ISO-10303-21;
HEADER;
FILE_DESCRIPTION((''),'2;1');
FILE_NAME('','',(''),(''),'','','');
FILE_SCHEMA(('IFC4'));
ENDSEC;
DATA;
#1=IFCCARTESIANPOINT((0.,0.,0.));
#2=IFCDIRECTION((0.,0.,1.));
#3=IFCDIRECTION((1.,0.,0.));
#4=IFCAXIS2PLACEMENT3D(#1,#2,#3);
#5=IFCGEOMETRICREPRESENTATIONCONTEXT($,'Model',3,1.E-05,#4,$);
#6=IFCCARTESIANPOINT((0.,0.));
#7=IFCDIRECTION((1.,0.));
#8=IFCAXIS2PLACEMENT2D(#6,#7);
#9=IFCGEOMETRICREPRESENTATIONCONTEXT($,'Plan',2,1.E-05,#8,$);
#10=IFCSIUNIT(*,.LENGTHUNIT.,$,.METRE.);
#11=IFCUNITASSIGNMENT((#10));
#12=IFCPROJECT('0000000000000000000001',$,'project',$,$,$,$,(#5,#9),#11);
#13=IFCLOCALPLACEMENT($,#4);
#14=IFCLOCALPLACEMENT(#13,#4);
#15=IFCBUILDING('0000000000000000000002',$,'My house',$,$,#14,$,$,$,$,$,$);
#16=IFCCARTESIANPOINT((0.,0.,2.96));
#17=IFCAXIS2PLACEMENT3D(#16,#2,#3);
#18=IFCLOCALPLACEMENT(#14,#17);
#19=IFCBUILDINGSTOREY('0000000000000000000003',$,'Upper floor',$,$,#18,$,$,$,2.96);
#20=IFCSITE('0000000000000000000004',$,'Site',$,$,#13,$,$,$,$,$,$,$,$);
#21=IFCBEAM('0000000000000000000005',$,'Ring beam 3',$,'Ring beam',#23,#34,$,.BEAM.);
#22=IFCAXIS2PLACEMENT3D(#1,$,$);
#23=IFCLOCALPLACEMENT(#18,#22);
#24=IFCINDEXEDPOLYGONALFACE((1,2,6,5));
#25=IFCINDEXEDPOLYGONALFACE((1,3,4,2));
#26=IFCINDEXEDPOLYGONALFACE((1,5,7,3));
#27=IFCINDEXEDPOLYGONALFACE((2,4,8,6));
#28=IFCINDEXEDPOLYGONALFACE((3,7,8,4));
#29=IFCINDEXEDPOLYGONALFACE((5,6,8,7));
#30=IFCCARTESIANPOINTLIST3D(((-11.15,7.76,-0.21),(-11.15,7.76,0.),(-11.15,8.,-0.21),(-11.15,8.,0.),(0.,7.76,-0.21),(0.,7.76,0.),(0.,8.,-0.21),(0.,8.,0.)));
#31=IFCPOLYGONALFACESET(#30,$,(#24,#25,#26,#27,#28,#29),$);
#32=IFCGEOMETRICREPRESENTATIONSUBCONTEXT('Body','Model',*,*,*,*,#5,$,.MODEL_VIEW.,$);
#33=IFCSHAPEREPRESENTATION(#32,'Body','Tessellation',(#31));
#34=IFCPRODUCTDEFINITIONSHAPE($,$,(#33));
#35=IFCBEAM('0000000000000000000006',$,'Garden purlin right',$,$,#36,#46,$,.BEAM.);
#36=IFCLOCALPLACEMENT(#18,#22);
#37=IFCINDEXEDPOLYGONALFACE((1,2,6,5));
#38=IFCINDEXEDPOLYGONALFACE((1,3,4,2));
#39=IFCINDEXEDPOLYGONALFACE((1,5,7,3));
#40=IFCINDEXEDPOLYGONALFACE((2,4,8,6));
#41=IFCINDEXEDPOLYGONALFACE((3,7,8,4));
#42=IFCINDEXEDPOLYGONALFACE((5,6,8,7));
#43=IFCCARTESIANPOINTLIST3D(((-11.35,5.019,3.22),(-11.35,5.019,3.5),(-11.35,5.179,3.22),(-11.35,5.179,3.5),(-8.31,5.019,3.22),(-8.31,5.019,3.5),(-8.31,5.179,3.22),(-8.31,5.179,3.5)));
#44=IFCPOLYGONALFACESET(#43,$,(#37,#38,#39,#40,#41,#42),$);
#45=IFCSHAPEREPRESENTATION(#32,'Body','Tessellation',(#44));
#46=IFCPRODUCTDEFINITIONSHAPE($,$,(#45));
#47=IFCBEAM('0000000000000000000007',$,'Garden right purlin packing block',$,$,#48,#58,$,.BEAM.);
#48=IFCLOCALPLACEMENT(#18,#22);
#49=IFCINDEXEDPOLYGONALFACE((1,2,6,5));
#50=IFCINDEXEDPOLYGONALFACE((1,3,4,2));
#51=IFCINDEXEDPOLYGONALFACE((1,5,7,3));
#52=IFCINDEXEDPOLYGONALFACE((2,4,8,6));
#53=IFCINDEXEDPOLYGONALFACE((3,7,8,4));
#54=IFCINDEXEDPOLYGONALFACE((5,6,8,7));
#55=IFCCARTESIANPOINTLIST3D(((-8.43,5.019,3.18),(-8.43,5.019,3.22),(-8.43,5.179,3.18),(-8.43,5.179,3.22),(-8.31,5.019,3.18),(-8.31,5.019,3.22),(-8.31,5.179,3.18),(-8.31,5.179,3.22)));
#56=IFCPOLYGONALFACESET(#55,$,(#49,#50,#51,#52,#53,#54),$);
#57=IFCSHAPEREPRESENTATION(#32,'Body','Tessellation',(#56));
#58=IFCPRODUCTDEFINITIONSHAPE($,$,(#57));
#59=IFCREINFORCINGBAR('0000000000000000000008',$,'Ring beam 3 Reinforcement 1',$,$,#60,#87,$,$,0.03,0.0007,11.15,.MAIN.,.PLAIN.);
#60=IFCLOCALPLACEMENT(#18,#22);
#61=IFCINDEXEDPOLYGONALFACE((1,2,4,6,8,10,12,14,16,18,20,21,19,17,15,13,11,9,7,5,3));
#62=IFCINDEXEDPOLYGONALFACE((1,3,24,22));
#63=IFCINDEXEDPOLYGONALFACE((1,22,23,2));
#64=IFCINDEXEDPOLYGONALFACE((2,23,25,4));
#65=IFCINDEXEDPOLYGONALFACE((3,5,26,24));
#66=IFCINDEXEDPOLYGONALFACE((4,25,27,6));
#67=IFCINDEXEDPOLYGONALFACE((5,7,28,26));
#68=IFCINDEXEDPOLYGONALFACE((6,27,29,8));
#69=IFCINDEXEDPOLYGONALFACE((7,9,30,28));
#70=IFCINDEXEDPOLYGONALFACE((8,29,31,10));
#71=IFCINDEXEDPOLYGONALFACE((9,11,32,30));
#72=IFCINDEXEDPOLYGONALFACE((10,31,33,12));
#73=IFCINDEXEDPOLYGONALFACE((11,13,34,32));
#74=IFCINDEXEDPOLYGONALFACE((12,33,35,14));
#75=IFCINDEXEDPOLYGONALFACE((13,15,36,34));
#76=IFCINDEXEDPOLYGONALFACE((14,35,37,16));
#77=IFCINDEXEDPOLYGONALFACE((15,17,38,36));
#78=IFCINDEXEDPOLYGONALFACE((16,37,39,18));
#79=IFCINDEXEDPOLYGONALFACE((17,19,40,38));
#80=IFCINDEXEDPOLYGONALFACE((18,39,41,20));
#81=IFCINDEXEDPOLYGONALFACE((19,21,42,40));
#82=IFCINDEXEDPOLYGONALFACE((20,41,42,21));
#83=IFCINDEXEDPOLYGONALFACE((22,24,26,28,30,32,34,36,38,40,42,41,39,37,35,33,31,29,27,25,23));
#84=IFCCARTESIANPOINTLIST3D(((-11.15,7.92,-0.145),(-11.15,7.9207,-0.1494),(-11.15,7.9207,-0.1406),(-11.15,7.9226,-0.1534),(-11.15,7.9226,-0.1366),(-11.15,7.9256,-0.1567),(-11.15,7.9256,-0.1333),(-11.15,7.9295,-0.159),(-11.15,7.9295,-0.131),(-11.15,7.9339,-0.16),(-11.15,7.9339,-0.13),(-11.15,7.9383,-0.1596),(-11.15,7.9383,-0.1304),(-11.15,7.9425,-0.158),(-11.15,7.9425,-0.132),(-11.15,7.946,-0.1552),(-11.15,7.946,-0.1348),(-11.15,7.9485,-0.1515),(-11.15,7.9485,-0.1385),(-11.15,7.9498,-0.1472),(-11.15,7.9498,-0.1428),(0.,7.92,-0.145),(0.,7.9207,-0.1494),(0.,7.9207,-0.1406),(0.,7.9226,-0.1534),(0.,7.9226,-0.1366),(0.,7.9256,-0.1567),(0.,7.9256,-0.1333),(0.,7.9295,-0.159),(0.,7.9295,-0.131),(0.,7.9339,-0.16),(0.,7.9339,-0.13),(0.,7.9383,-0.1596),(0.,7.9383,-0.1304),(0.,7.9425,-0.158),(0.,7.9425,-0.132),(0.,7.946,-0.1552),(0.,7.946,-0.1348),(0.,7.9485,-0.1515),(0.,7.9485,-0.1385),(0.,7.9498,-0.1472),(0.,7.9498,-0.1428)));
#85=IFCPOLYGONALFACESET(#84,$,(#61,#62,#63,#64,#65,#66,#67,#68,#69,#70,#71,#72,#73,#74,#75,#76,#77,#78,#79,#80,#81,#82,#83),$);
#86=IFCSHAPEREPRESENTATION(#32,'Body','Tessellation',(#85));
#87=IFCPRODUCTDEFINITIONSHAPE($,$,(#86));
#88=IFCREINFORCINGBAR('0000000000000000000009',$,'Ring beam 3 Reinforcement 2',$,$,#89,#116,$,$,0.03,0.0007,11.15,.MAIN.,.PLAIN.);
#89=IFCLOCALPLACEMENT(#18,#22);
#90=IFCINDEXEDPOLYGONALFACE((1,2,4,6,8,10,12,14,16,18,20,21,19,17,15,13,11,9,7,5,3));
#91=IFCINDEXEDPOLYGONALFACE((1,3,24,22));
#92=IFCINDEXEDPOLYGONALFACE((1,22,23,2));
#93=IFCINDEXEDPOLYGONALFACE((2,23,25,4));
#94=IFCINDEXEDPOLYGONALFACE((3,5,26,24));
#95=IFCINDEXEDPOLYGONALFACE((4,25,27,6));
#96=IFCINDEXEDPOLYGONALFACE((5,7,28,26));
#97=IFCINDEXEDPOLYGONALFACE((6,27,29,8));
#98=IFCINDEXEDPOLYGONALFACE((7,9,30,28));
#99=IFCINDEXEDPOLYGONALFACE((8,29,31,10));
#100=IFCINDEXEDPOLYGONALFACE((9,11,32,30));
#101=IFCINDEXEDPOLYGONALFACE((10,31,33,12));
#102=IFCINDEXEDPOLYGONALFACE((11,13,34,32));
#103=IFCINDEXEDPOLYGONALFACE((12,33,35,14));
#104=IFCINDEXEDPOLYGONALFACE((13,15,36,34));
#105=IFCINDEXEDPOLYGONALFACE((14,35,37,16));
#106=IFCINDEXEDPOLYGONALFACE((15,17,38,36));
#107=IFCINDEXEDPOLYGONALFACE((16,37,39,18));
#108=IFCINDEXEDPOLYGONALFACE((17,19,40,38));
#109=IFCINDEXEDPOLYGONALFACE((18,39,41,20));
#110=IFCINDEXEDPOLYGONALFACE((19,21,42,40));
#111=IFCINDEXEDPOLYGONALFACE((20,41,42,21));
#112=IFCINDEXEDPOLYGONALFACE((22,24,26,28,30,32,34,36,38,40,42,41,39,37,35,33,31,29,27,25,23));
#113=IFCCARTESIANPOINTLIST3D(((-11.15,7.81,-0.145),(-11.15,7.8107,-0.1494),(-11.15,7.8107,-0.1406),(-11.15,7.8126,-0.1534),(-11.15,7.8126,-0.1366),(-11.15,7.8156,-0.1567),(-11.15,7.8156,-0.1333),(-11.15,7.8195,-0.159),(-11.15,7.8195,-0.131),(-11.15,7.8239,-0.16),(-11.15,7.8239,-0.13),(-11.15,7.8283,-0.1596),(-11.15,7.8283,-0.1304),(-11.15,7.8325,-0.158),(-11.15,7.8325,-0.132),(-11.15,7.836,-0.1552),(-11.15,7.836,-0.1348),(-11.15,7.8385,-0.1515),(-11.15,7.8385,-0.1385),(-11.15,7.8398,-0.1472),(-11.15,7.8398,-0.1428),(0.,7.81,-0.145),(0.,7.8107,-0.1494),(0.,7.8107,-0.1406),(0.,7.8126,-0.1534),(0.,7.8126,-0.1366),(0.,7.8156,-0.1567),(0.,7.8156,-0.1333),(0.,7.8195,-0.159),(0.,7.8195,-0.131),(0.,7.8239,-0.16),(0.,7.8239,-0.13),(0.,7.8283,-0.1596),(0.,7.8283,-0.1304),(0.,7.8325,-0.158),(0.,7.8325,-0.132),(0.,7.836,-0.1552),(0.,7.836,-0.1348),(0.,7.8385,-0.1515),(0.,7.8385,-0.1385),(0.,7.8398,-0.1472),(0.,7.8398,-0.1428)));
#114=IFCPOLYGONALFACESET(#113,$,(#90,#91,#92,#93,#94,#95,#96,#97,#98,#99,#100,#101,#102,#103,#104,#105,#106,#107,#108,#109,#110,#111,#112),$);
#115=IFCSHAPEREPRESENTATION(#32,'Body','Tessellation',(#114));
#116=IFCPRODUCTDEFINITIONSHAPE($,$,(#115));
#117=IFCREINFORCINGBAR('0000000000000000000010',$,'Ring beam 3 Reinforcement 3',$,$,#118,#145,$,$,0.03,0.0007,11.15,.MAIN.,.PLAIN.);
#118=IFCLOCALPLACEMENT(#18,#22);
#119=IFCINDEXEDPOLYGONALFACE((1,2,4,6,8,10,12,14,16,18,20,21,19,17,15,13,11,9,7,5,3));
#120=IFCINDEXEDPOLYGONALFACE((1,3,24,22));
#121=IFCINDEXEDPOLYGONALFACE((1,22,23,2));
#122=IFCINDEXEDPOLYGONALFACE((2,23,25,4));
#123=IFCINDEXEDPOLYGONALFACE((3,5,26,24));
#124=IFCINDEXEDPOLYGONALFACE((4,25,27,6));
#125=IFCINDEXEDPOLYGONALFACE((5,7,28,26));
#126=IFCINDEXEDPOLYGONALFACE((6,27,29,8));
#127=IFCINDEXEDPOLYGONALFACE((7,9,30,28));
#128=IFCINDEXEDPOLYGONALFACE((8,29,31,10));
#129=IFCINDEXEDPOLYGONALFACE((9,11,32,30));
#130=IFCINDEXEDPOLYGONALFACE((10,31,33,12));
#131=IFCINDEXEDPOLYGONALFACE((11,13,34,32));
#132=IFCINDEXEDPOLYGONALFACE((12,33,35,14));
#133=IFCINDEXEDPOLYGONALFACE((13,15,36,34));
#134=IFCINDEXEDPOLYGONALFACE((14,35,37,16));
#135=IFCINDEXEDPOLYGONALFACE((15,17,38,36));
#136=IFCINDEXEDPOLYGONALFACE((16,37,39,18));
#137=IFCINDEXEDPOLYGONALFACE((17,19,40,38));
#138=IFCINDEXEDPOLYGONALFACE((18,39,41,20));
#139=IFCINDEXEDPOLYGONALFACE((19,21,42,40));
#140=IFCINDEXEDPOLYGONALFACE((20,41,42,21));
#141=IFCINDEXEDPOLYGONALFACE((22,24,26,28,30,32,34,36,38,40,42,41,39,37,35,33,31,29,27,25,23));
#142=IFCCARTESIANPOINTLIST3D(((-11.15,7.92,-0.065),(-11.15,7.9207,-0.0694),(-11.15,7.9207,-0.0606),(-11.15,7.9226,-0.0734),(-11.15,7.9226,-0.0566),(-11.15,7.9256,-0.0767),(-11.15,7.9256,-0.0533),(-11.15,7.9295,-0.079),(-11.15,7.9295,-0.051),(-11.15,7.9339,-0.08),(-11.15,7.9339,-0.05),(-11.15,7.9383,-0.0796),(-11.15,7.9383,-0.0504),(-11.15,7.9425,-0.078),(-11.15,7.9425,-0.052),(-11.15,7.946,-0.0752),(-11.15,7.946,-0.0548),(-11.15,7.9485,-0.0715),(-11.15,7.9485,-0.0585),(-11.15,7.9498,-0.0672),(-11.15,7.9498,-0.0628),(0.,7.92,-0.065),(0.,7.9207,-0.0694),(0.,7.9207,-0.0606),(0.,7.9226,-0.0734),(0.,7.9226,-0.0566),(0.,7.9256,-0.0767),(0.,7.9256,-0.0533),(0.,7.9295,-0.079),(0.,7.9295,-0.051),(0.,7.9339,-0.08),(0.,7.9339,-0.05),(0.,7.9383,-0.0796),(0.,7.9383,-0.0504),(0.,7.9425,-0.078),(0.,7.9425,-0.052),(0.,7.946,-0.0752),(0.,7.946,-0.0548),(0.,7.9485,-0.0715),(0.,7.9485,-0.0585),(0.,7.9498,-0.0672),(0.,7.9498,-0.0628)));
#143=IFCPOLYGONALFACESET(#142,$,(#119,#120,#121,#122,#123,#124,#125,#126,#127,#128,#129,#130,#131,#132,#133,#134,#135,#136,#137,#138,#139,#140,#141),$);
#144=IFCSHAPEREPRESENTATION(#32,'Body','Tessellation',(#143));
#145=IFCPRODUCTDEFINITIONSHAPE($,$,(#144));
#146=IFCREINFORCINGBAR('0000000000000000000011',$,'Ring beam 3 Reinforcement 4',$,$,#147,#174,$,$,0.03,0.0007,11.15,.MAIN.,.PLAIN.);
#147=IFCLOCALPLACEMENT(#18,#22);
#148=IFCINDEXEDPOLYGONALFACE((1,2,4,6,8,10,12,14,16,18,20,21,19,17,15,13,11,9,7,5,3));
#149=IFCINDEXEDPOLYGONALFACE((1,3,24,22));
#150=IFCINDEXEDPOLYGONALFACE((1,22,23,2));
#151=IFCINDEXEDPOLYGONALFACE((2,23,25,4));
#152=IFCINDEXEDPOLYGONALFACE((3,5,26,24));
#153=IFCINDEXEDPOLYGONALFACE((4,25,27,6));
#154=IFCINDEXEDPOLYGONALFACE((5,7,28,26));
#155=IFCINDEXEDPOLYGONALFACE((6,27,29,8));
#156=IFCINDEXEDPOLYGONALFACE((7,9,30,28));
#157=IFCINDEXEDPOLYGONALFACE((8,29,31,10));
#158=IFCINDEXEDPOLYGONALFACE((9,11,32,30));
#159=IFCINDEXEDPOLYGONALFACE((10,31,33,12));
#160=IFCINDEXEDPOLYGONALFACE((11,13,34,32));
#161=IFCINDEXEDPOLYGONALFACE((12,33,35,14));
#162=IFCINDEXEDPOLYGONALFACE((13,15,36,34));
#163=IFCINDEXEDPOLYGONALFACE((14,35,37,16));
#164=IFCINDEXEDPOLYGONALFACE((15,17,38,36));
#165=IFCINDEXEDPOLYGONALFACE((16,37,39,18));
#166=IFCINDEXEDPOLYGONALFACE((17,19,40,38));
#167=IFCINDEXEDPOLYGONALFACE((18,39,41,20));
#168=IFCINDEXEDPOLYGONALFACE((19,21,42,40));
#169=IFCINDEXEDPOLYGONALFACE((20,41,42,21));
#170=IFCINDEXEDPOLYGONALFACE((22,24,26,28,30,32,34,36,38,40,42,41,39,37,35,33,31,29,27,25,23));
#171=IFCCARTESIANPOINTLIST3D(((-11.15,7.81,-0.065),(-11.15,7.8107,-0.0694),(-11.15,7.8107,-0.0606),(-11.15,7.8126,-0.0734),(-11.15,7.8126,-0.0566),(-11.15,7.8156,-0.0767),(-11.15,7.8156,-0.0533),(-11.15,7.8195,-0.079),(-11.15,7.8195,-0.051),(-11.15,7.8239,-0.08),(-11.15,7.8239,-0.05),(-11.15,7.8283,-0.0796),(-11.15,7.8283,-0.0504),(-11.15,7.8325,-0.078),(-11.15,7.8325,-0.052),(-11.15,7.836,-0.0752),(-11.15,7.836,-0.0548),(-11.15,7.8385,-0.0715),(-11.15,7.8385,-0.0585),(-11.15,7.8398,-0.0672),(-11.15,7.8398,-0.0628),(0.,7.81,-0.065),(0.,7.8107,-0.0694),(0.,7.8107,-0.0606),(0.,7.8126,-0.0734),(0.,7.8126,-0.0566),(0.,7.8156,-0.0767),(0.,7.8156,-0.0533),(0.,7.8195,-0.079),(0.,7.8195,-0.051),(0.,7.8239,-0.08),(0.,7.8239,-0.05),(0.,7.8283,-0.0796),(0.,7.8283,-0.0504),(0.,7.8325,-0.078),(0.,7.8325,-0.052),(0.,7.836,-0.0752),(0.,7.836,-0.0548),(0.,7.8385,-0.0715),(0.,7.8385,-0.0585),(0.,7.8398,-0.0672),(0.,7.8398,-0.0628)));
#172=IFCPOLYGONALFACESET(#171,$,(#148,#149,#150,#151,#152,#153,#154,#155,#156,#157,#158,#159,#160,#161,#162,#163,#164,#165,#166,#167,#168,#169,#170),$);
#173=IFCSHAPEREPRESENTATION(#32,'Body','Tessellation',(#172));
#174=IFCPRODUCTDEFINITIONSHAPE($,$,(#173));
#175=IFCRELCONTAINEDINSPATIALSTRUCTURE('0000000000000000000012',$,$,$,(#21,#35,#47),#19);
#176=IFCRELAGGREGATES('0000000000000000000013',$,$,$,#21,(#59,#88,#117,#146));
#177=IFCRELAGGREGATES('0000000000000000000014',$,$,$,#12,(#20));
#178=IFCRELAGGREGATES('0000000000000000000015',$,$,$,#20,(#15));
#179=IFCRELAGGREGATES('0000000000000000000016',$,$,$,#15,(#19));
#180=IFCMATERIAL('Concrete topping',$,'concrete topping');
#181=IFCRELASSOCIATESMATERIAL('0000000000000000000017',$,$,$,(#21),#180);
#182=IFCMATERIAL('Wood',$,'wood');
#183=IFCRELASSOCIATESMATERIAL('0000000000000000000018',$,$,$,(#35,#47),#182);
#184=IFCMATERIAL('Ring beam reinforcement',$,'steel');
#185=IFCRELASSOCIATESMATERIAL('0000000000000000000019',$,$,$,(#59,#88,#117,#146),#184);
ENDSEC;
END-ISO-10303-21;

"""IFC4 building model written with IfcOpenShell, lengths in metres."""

from ifc_helpers import new_model, si_unit, frame, origin_with_axes, origin_2d, origin_2d_with_axis, place, context, subcontext, project, spatial, circle_curve, rectangle, outline, extrude, source, transform, mapped, material, element, aggregate, save


model = new_model("IFC4")

# Units and contexts
model_context = context("Model", 3, precision=1e-05, world=origin_with_axes())
plan_context = context("Plan", 2, precision=1e-05, world=origin_2d_with_axis())
body_context_1 = subcontext(model_context, "Body", "Model", "MODEL_VIEW")
ifc_project = project(units=[si_unit("LENGTHUNIT", "METRE")], contexts=[model_context, plan_context])

# Site, building, storey
site_placement = place(None, origin_with_axes())
site = spatial("IfcSite", under=ifc_project, at=site_placement, Name="Site")
building_placement = place(site_placement, origin_with_axes())
building = spatial("IfcBuilding", under=site, at=building_placement, Name="My house")
storey_placement = place(building_placement, frame((0.0, 0.0, 2.96), z_axis=(0.0, 0.0, 1.0), x_axis=(1.0, 0.0, 0.0)))
storey = spatial("IfcBuildingStorey", under=building, at=storey_placement, Name="Upper floor", Elevation=2.96)

# Beam
ifc_material_1 = material(Name="Concrete topping", Category="concrete topping")
shared_shape_1 = source(origin_with_axes(), body_context_1, "Body", "SweptSolid", [
    extrude(rectangle(XDim=0.24, YDim=0.21), frame((0.0, 0.0, 0.0), z_axis=(1.0, 0.0, 0.0), x_axis=(0.0, 1.0, 0.0)), (0.0, 0.0, 1.0), 11.15),
])
beam_1_placement = place(storey_placement, frame((-11.15, 7.88, -0.105), z_axis=(0.0, 0.0, 1.0), x_axis=(-1.0, 0.0, 0.0)))
beam_1 = element("IfcBeam", 1, at=beam_1_placement, inside=storey, material=ifc_material_1, Name="Ring beam 3", ObjectType="Ring beam", PredefinedType="BEAM", context=body_context_1, shape_type="MappedRepresentation", body=[
    mapped(shared_shape_1, transform((0.0, 0.0, 0.0), x_axis=(-1.0, 0.0, 0.0), y_axis=(0.0, 1.0, 0.0), z_axis=(0.0, 0.0, 1.0), scale=1.0)),
])

# Beams
ifc_material_2 = material(Name="Wood", Category="wood")
shared_shape_2 = source(origin_with_axes(), body_context_1, "Body", "SweptSolid", [
    extrude(rectangle(XDim=0.16, YDim=0.28), frame((0.0, 0.0, 0.0), z_axis=(1.0, 0.0, 0.0), x_axis=(0.0, 1.0, 0.0)), (0.0, 0.0, 1.0), 3.04),
])
beam_2_placement = place(storey_placement, frame((-8.31, 5.099, 3.36), z_axis=(0.0, 0.0, 1.0), x_axis=(1.0, 0.0, 0.0)))
element("IfcBeam", 2, at=beam_2_placement, inside=storey, material=ifc_material_2, Name="Garden purlin right", PredefinedType="BEAM", context=body_context_1, shape_type="MappedRepresentation", body=[
    mapped(shared_shape_2, transform((0.0, 0.0, 0.0), x_axis=(-1.0, 0.0, 0.0), y_axis=(0.0, 1.0, 0.0), z_axis=(0.0, 0.0, 1.0), scale=1.0)),
])
shared_shape_3 = source(origin_with_axes(), body_context_1, "Body", "SweptSolid", [
    extrude(rectangle(XDim=0.16, YDim=0.04), frame((0.0, 0.0, 0.0), z_axis=(1.0, 0.0, 0.0), x_axis=(0.0, 1.0, 0.0)), (0.0, 0.0, 1.0), 0.12),
])
beam_3_placement = place(storey_placement, frame((-8.31, 5.099, 3.2), z_axis=(0.0, 0.0, 1.0), x_axis=(1.0, 0.0, 0.0)))
element("IfcBeam", 3, at=beam_3_placement, inside=storey, material=ifc_material_2, Name="Garden right purlin packing block", PredefinedType="BEAM", context=body_context_1, shape_type="MappedRepresentation", body=[
    mapped(shared_shape_3, transform((0.0, 0.0, 0.0), x_axis=(-1.0, 0.0, 0.0), y_axis=(0.0, 1.0, 0.0), z_axis=(0.0, 0.0, 1.0), scale=1.0)),
])

# Reinforcing bars
ifc_material_3 = material(Name="Ring beam reinforcement", Category="steel")
shared_shape_4 = source(origin_with_axes(), body_context_1, "Body", "SweptSolid", [
    extrude(outline(circle_curve(origin_2d(), 0.015)), frame((0.0, 0.0, 0.0), z_axis=(1.0, 0.0, 0.0), x_axis=(0.0, 1.0, 0.0)), (0.0, 0.0, 1.0), 11.15),
])
reinforcing_bar_1_placement = place(beam_1_placement, frame((0.0, -0.055, -0.04), z_axis=(0.0, 0.0, 1.0), x_axis=(1.0, 0.0, 0.0)))
reinforcing_bar_1 = element("IfcReinforcingBar", 4, at=reinforcing_bar_1_placement, material=ifc_material_3, Name="Ring beam 3 Reinforcement 1", BarLength=11.15, BarSurface="PLAIN", CrossSectionArea=0.0007, NominalDiameter=0.03, PredefinedType="MAIN", context=body_context_1, shape_type="MappedRepresentation", body=[
    mapped(shared_shape_4, transform((0.0, 0.0, 0.0), x_axis=(-1.0, 0.0, 0.0), y_axis=(0.0, 1.0, 0.0), z_axis=(0.0, 0.0, 1.0), scale=1.0)),
])
shared_shape_5 = source(origin_with_axes(), body_context_1, "Body", "SweptSolid", [
    extrude(outline(circle_curve(origin_2d(), 0.015)), frame((0.0, 0.0, 0.0), z_axis=(1.0, 0.0, 0.0), x_axis=(0.0, 1.0, 0.0)), (0.0, 0.0, 1.0), 11.15),
])
reinforcing_bar_2_placement = place(beam_1_placement, frame((0.0, 0.055, -0.04), z_axis=(0.0, 0.0, 1.0), x_axis=(1.0, 0.0, 0.0)))
reinforcing_bar_2 = element("IfcReinforcingBar", 5, at=reinforcing_bar_2_placement, material=ifc_material_3, Name="Ring beam 3 Reinforcement 2", BarLength=11.15, BarSurface="PLAIN", CrossSectionArea=0.0007, NominalDiameter=0.03, PredefinedType="MAIN", context=body_context_1, shape_type="MappedRepresentation", body=[
    mapped(shared_shape_5, transform((0.0, 0.0, 0.0), x_axis=(-1.0, 0.0, 0.0), y_axis=(0.0, 1.0, 0.0), z_axis=(0.0, 0.0, 1.0), scale=1.0)),
])
shared_shape_6 = source(origin_with_axes(), body_context_1, "Body", "SweptSolid", [
    extrude(outline(circle_curve(origin_2d(), 0.015)), frame((0.0, 0.0, 0.0), z_axis=(1.0, 0.0, 0.0), x_axis=(0.0, 1.0, 0.0)), (0.0, 0.0, 1.0), 11.15),
])
reinforcing_bar_3_placement = place(beam_1_placement, frame((0.0, -0.055, 0.04), z_axis=(0.0, 0.0, 1.0), x_axis=(1.0, 0.0, 0.0)))
reinforcing_bar_3 = element("IfcReinforcingBar", 6, at=reinforcing_bar_3_placement, material=ifc_material_3, Name="Ring beam 3 Reinforcement 3", BarLength=11.15, BarSurface="PLAIN", CrossSectionArea=0.0007, NominalDiameter=0.03, PredefinedType="MAIN", context=body_context_1, shape_type="MappedRepresentation", body=[
    mapped(shared_shape_6, transform((0.0, 0.0, 0.0), x_axis=(-1.0, 0.0, 0.0), y_axis=(0.0, 1.0, 0.0), z_axis=(0.0, 0.0, 1.0), scale=1.0)),
])
shared_shape_7 = source(origin_with_axes(), body_context_1, "Body", "SweptSolid", [
    extrude(outline(circle_curve(origin_2d(), 0.015)), frame((0.0, 0.0, 0.0), z_axis=(1.0, 0.0, 0.0), x_axis=(0.0, 1.0, 0.0)), (0.0, 0.0, 1.0), 11.15),
])
reinforcing_bar_4_placement = place(beam_1_placement, frame((0.0, 0.055, 0.04), z_axis=(0.0, 0.0, 1.0), x_axis=(1.0, 0.0, 0.0)))
reinforcing_bar_4 = element("IfcReinforcingBar", 7, at=reinforcing_bar_4_placement, material=ifc_material_3, Name="Ring beam 3 Reinforcement 4", BarLength=11.15, BarSurface="PLAIN", CrossSectionArea=0.0007, NominalDiameter=0.03, PredefinedType="MAIN", context=body_context_1, shape_type="MappedRepresentation", body=[
    mapped(shared_shape_7, transform((0.0, 0.0, 0.0), x_axis=(-1.0, 0.0, 0.0), y_axis=(0.0, 1.0, 0.0), z_axis=(0.0, 0.0, 1.0), scale=1.0)),
])
aggregate(beam_1, [reinforcing_bar_1, reinforcing_bar_2, reinforcing_bar_3, reinforcing_bar_4])

save(model, "model.ifc")
